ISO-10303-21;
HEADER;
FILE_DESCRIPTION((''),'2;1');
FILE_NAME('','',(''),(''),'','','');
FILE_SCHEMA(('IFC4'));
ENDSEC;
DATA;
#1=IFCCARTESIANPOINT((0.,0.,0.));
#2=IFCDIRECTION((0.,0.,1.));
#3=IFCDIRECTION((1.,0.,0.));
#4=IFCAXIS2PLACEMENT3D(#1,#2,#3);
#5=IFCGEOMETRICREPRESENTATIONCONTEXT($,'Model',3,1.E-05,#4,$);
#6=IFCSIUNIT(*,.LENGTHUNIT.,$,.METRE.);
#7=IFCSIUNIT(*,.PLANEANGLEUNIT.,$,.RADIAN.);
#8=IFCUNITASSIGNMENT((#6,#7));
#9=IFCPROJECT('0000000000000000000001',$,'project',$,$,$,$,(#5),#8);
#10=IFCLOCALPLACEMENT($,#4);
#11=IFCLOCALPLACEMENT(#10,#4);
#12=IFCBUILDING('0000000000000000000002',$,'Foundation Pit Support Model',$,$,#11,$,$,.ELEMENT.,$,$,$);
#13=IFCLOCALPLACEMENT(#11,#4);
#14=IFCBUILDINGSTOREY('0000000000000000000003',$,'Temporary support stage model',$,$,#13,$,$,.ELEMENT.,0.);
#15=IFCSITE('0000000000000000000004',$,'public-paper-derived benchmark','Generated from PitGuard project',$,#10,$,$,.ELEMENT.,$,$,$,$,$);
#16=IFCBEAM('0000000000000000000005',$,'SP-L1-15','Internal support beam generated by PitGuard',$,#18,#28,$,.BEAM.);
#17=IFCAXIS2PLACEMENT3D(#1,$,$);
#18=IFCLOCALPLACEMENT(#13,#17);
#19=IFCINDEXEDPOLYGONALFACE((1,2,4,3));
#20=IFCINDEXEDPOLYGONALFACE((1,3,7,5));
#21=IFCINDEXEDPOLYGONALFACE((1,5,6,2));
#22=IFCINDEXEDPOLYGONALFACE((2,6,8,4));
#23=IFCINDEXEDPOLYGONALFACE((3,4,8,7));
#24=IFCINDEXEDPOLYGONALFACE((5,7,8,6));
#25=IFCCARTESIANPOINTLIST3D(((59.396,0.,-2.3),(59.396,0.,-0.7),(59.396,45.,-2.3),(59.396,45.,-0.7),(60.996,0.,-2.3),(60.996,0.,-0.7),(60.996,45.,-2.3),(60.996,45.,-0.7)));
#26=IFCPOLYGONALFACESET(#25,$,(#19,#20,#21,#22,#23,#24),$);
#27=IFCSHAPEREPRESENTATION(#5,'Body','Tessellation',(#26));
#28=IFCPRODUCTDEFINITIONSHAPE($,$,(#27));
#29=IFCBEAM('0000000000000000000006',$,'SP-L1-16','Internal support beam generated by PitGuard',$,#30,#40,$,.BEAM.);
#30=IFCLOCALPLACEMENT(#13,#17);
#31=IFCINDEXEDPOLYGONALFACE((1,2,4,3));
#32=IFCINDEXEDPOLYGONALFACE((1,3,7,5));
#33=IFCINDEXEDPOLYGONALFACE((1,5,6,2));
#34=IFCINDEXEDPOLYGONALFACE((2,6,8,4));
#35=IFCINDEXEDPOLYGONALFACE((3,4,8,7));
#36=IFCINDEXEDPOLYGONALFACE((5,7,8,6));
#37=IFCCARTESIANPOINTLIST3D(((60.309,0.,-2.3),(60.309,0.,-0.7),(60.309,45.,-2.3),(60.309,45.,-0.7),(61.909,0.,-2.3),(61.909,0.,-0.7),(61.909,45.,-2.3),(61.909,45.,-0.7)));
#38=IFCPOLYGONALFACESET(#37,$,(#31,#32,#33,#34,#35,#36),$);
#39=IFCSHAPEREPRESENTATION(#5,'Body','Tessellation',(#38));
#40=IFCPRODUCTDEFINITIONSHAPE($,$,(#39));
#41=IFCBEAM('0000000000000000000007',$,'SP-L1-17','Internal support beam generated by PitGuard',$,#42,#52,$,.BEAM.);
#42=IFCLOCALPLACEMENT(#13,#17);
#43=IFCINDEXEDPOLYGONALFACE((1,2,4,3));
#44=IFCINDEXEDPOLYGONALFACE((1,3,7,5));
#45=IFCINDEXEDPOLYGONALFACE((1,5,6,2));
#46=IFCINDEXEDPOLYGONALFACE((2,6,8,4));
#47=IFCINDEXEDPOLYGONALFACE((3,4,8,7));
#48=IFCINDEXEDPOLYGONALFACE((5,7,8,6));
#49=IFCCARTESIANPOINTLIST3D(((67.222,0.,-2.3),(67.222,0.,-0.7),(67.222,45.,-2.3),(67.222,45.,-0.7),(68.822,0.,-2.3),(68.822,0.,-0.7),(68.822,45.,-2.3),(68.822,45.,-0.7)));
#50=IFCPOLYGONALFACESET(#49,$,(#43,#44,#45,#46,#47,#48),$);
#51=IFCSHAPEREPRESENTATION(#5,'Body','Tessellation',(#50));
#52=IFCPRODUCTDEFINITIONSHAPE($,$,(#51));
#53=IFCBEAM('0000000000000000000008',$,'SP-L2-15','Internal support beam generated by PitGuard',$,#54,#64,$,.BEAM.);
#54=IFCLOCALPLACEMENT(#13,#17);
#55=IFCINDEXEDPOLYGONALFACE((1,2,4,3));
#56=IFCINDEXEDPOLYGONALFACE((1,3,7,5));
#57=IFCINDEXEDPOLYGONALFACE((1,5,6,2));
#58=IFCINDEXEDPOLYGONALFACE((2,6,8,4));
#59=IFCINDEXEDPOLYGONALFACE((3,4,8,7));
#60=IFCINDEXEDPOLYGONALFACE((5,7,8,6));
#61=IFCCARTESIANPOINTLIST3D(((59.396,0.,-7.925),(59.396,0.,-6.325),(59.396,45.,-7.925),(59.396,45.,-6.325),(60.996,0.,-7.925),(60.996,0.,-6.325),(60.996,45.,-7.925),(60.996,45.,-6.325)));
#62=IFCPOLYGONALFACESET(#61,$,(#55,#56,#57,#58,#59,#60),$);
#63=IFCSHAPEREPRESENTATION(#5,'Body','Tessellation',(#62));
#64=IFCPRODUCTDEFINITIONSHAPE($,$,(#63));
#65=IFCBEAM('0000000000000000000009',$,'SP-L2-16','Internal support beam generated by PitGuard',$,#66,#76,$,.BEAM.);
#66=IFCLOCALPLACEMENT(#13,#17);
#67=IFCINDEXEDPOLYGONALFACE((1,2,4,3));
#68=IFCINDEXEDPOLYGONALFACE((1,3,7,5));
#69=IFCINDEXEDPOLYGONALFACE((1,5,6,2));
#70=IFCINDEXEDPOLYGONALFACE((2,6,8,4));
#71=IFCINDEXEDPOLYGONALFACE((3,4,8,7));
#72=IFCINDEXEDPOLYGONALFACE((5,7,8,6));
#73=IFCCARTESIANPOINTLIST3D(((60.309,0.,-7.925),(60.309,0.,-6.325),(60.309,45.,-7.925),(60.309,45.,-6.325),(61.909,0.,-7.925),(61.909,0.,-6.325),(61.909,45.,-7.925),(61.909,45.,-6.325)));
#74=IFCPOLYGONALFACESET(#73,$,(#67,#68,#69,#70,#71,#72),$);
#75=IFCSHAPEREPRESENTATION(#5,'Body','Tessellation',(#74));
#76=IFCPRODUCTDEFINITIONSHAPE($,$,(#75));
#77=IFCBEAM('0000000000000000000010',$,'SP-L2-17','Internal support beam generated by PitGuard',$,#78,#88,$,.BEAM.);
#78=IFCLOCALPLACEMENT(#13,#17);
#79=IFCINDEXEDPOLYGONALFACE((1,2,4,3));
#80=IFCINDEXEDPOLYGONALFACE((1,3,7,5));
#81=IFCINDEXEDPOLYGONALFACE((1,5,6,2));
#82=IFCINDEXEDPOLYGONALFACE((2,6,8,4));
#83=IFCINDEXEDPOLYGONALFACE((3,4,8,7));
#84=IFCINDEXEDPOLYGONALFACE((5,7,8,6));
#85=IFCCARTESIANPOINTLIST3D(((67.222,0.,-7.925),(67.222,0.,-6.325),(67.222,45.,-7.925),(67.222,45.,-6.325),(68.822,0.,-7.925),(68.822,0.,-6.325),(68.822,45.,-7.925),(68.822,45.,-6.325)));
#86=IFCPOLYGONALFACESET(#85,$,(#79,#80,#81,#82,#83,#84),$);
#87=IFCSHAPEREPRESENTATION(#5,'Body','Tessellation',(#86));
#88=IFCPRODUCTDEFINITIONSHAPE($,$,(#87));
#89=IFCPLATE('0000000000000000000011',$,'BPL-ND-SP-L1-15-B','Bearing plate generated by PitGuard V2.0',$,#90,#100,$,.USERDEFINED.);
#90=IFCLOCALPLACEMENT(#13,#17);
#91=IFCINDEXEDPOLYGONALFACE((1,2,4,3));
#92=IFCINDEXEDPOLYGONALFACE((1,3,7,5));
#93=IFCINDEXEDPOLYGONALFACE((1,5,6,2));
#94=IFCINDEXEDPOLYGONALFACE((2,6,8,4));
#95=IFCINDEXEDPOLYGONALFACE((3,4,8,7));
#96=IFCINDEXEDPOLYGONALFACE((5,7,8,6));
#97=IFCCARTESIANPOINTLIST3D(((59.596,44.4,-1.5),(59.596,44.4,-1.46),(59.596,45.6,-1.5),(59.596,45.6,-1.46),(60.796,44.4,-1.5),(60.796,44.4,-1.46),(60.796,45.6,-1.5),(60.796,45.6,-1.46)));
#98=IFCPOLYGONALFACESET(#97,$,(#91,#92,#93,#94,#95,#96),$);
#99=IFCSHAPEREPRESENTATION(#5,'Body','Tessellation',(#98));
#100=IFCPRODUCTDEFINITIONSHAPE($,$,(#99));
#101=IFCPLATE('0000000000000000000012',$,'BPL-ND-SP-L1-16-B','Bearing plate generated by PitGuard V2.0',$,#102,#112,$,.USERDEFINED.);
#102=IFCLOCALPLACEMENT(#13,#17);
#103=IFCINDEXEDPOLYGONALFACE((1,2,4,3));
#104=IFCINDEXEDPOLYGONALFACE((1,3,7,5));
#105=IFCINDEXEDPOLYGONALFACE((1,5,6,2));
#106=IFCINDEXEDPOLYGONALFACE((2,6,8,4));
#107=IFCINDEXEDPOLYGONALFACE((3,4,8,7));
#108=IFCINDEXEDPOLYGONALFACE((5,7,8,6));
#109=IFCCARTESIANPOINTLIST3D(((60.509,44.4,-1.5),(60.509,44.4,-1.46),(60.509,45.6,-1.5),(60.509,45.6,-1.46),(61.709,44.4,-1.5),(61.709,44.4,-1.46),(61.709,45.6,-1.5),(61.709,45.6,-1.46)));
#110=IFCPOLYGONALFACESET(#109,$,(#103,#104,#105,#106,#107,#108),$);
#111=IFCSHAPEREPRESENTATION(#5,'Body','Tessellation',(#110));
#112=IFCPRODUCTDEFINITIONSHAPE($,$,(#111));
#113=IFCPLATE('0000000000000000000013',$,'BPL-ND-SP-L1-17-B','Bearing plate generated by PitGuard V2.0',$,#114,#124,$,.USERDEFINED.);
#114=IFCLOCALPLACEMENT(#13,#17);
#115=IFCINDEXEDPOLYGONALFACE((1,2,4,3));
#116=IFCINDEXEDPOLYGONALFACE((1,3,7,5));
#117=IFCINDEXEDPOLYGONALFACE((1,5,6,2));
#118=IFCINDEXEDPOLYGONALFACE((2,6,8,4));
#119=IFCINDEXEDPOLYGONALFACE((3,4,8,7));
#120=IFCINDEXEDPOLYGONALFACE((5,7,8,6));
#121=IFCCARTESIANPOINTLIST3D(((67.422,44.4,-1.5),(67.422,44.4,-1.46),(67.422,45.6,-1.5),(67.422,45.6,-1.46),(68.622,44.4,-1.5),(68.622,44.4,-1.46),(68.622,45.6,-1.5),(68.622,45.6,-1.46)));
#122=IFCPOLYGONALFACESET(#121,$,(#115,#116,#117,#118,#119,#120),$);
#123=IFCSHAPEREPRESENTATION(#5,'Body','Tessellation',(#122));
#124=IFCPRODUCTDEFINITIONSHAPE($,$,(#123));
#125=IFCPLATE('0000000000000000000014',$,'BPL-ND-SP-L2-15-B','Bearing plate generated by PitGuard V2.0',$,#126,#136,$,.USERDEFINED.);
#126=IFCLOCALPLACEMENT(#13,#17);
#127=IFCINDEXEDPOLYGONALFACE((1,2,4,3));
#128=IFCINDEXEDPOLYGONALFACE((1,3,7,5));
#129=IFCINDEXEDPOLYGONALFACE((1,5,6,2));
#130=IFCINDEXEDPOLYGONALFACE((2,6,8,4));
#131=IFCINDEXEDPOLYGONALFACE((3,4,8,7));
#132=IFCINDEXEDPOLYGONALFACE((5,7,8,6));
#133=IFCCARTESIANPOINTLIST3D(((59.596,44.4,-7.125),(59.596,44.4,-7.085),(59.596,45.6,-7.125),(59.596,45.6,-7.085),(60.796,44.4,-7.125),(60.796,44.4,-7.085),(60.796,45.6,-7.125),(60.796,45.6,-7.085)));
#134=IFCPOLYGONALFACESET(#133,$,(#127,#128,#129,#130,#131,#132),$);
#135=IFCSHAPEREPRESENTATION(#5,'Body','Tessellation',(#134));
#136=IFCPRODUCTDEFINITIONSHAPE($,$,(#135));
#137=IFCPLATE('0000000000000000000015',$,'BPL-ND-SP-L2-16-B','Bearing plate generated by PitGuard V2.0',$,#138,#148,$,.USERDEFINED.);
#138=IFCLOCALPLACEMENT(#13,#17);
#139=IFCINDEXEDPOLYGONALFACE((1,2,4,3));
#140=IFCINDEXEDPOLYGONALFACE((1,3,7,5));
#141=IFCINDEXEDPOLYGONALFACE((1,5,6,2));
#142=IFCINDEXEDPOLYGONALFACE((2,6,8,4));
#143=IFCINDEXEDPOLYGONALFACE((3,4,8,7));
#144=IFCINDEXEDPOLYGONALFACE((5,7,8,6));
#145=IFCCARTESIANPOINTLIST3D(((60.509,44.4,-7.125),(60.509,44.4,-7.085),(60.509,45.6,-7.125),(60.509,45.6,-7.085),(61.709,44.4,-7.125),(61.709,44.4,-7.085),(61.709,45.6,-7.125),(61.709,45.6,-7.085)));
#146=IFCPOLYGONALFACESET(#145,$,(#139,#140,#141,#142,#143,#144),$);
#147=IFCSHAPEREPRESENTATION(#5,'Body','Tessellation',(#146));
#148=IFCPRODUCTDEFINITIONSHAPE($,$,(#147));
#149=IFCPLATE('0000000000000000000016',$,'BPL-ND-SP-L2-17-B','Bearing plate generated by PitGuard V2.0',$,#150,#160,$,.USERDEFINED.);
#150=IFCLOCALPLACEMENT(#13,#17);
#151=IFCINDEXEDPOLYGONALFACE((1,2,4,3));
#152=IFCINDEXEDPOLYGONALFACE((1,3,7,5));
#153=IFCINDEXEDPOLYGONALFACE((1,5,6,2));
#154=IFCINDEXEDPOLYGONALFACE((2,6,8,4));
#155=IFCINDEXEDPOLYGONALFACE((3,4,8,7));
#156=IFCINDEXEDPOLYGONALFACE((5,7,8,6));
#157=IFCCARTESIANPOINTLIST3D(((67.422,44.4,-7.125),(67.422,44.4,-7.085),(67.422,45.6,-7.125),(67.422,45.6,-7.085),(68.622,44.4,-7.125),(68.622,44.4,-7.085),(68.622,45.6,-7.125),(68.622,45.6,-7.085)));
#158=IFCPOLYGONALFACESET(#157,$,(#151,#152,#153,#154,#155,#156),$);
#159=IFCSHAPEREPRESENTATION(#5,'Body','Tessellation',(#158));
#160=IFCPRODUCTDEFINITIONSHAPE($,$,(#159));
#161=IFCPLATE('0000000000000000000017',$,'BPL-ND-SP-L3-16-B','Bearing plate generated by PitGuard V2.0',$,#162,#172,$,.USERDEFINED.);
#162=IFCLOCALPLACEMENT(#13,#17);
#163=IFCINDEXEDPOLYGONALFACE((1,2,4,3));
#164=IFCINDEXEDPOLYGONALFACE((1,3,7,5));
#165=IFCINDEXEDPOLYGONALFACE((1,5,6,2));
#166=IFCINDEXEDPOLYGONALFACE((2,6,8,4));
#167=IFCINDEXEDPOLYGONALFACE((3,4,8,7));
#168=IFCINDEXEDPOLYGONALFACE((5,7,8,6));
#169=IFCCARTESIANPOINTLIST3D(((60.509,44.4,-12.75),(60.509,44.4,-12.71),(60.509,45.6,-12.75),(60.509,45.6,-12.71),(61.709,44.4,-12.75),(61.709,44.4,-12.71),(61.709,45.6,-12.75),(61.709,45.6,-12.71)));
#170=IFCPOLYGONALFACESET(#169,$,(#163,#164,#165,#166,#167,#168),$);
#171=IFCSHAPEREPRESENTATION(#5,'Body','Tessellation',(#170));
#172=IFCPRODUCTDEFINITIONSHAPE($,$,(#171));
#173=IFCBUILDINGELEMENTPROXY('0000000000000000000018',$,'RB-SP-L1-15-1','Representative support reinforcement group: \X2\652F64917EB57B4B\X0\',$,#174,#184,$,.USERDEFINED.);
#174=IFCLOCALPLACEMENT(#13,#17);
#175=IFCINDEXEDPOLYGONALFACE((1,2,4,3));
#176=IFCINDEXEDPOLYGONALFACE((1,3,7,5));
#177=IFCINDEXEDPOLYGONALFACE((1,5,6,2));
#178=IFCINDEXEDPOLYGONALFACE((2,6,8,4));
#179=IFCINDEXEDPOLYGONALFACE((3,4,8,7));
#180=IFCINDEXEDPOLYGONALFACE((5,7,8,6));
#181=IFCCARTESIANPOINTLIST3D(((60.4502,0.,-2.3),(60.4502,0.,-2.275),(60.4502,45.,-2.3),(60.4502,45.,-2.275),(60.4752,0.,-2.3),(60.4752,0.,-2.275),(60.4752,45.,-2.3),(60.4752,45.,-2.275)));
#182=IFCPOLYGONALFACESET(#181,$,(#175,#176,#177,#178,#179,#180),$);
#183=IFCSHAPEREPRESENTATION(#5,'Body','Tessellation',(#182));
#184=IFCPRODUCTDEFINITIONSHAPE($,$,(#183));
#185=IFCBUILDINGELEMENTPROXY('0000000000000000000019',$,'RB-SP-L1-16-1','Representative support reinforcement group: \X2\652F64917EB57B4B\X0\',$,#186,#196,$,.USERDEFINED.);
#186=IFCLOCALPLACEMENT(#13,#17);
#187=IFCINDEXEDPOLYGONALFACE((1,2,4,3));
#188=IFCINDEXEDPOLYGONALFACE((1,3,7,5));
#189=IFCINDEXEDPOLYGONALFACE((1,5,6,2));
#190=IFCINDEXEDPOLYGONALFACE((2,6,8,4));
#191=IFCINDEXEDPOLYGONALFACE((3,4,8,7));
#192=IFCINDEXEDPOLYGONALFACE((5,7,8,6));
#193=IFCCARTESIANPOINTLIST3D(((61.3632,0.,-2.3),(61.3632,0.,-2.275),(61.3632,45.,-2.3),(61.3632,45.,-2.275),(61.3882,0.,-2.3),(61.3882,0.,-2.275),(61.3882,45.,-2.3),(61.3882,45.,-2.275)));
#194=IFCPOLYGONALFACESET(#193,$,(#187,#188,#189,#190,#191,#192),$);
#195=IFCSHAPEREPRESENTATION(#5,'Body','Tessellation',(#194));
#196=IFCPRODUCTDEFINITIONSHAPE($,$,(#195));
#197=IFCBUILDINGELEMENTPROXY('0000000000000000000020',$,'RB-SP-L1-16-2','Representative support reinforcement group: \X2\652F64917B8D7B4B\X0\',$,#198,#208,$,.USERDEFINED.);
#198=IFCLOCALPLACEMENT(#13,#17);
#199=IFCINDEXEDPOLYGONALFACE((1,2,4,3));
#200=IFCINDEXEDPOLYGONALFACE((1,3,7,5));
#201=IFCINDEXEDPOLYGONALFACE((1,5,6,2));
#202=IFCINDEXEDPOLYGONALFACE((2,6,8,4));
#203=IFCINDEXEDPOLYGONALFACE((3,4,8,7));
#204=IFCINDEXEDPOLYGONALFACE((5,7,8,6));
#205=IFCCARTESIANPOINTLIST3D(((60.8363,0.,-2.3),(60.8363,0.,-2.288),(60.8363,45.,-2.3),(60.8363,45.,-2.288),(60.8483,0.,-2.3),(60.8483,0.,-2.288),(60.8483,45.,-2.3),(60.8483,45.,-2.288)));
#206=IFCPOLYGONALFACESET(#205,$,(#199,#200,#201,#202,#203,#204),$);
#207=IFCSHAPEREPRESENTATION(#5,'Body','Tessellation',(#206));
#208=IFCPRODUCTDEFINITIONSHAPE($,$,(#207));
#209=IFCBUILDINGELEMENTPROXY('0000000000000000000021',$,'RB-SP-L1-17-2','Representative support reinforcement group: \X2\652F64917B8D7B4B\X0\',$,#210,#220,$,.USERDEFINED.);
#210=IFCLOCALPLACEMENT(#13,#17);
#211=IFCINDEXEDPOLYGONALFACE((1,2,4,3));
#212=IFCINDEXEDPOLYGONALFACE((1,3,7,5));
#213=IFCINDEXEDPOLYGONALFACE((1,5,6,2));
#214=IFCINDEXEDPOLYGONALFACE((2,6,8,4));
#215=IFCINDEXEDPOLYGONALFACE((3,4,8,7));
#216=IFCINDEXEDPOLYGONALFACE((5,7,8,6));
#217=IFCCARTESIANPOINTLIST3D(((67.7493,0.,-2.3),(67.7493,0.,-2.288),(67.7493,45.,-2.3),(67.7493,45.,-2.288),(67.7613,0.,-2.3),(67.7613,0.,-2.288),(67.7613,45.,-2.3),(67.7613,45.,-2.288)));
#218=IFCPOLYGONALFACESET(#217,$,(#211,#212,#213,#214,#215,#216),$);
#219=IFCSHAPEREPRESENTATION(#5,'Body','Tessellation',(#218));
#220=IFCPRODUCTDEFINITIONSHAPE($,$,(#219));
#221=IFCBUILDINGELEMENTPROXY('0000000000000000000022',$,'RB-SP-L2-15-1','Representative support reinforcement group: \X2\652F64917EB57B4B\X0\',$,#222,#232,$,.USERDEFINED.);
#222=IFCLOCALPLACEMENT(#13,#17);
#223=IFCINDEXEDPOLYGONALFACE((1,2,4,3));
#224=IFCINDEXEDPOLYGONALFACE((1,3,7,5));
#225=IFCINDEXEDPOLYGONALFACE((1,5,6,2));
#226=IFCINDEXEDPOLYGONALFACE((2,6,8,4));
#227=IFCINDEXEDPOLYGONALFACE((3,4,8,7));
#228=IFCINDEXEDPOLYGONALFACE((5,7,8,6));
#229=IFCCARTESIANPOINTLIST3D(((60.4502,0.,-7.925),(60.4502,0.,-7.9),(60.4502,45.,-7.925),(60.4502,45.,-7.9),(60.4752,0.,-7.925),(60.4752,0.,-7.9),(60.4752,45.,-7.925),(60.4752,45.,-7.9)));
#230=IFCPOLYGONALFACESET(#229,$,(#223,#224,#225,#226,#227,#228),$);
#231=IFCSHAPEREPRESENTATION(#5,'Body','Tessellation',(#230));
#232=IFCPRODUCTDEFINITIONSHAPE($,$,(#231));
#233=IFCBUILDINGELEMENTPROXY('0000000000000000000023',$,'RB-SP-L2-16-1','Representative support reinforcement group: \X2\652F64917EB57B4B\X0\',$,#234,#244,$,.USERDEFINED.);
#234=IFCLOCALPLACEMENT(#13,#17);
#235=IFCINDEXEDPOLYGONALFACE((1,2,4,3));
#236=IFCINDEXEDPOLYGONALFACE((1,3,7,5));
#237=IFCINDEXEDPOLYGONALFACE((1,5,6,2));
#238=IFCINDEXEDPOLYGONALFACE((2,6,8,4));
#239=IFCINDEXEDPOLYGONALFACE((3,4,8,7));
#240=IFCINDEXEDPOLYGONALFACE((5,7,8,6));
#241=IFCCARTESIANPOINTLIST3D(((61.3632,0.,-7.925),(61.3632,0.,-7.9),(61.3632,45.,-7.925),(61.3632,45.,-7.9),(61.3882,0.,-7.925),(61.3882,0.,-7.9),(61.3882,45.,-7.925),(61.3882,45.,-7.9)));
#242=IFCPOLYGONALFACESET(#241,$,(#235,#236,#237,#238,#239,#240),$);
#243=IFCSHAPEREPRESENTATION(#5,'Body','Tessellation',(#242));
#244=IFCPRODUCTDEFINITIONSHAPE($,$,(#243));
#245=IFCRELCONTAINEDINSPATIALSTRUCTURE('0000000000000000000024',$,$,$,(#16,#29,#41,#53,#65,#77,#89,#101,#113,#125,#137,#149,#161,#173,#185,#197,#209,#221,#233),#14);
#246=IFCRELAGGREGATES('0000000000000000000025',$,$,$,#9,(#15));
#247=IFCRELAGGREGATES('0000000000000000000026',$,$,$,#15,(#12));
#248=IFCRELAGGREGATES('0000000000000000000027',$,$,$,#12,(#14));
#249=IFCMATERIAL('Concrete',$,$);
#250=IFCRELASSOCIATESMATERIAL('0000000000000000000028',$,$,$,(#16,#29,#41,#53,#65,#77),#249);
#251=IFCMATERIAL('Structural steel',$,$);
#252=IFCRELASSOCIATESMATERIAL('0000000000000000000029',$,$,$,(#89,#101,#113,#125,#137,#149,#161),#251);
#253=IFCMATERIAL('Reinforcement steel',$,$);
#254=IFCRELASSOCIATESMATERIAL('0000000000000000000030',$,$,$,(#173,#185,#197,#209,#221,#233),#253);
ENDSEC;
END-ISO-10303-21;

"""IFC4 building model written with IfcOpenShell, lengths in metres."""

from ifc_helpers import new_model, si_unit, frame, origin_with_axes, origin_2d, place, context, project, spatial, rectangle, extrude, material, element, save


model = new_model("IFC4")

# Units and contexts
model_context = context("Model", 3, precision=1e-05, world=origin_with_axes())
ifc_project = project(units=[si_unit("LENGTHUNIT", "METRE"), si_unit("PLANEANGLEUNIT", "RADIAN")], contexts=[model_context])

# Site, building, storey
site_placement = place(None, origin_with_axes())
site = spatial("IfcSite", under=ifc_project, at=site_placement, Name="public-paper-derived benchmark", Description="Generated from PitGuard project", CompositionType="ELEMENT")
building_placement = place(site_placement, origin_with_axes())
building = spatial("IfcBuilding", under=site, at=building_placement, Name="Foundation Pit Support Model", CompositionType="ELEMENT")
storey_placement = place(building_placement, origin_with_axes())
storey = spatial("IfcBuildingStorey", under=building, at=storey_placement, Name="Temporary support stage model", CompositionType="ELEMENT", Elevation=0.0)

# Beams
ifc_material_1 = material(Name="Concrete")
for number, where, z_axis, x_axis, name in (
    (1, (60.196, 22.5, -2.3), (0.0, 0.0, 1.0), (0.0, 1.0, 0.0), "SP-L1-15"),
    (2, (61.109, 22.5, -2.3), (0.0, 0.0, 1.0), (0.0, 1.0, 0.0), "SP-L1-16"),
    (3, (68.022, 22.5, -2.3), (0.0, 0.0, 1.0), (0.0, 1.0, 0.0), "SP-L1-17"),
    (4, (60.196, 22.5, -7.925), (0.0, 0.0, 1.0), (0.0, 1.0, 0.0), "SP-L2-15"),
    (5, (61.109, 22.5, -7.925), (0.0, 0.0, 1.0), (0.0, 1.0, 0.0), "SP-L2-16"),
    (6, (68.022, 22.5, -7.925), (0.0, 0.0, 1.0), (0.0, 1.0, 0.0), "SP-L2-17"),
):
    element("IfcBeam", number, at=place(storey_placement, frame(where, z_axis=z_axis, x_axis=x_axis)), inside=storey, material=ifc_material_1, Name=name, Description="Internal support beam generated by PitGuard", PredefinedType="BEAM", context=model_context, shape_type="SweptSolid", body=[
        extrude(rectangle(XDim=45.0, YDim=1.6, at=origin_2d()), origin_with_axes(), (0.0, 0.0, 1.0), 1.6),
    ])

# Plates
ifc_material_2 = material(Name="Structural steel")
for number, where, z_axis, x_axis, name in (
    (7, (60.196, 45.0, -1.5), (0.0, 0.0, 1.0), (1.0, 0.0, 0.0), "BPL-ND-SP-L1-15-B"),
    (8, (61.109, 45.0, -1.5), (0.0, 0.0, 1.0), (1.0, 0.0, 0.0), "BPL-ND-SP-L1-16-B"),
    (9, (68.022, 45.0, -1.5), (0.0, 0.0, 1.0), (1.0, 0.0, 0.0), "BPL-ND-SP-L1-17-B"),
    (10, (60.196, 45.0, -7.125), (0.0, 0.0, 1.0), (1.0, 0.0, 0.0), "BPL-ND-SP-L2-15-B"),
    (11, (61.109, 45.0, -7.125), (0.0, 0.0, 1.0), (1.0, 0.0, 0.0), "BPL-ND-SP-L2-16-B"),
    (12, (68.022, 45.0, -7.125), (0.0, 0.0, 1.0), (1.0, 0.0, 0.0), "BPL-ND-SP-L2-17-B"),
    (13, (61.109, 45.0, -12.75), (0.0, 0.0, 1.0), (1.0, 0.0, 0.0), "BPL-ND-SP-L3-16-B"),
):
    element("IfcPlate", number, at=place(storey_placement, frame(where, z_axis=z_axis, x_axis=x_axis)), inside=storey, material=ifc_material_2, Name=name, Description="Bearing plate generated by PitGuard V2.0", PredefinedType="USERDEFINED", context=model_context, shape_type="SweptSolid", body=[
        extrude(rectangle(XDim=1.2, YDim=1.2, at=origin_2d()), origin_with_axes(), (0.0, 0.0, 1.0), 0.04),
    ])

# Building element proxies
ifc_material_3 = material(Name="Reinforcement steel")
for number, where, z_axis, x_axis, name in (
    (14, (60.4627, 22.5, -2.3), (0.0, 0.0, 1.0), (0.0, 1.0, 0.0), "RB-SP-L1-15-1"),
    (15, (61.3757, 22.5, -2.3), (0.0, 0.0, 1.0), (0.0, 1.0, 0.0), "RB-SP-L1-16-1"),
):
    element("IfcBuildingElementProxy", number, at=place(storey_placement, frame(where, z_axis=z_axis, x_axis=x_axis)), inside=storey, material=ifc_material_3, Name=name, Description="Representative support reinforcement group: 支撑纵筋", PredefinedType="USERDEFINED", context=model_context, shape_type="SweptSolid", body=[
        extrude(rectangle(XDim=45.0, YDim=0.025, at=origin_2d()), origin_with_axes(), (0.0, 0.0, 1.0), 0.025),
    ])
for number, where, z_axis, x_axis, name in (
    (16, (60.8423, 22.5, -2.3), (0.0, 0.0, 1.0), (0.0, 1.0, 0.0), "RB-SP-L1-16-2"),
    (17, (67.7553, 22.5, -2.3), (0.0, 0.0, 1.0), (0.0, 1.0, 0.0), "RB-SP-L1-17-2"),
):
    element("IfcBuildingElementProxy", number, at=place(storey_placement, frame(where, z_axis=z_axis, x_axis=x_axis)), inside=storey, material=ifc_material_3, Name=name, Description="Representative support reinforcement group: 支撑箍筋", PredefinedType="USERDEFINED", context=model_context, shape_type="SweptSolid", body=[
        extrude(rectangle(XDim=45.0, YDim=0.012, at=origin_2d()), origin_with_axes(), (0.0, 0.0, 1.0), 0.012),
    ])
for number, where, z_axis, x_axis, name in (
    (18, (60.4627, 22.5, -7.925), (0.0, 0.0, 1.0), (0.0, 1.0, 0.0), "RB-SP-L2-15-1"),
    (19, (61.3757, 22.5, -7.925), (0.0, 0.0, 1.0), (0.0, 1.0, 0.0), "RB-SP-L2-16-1"),
):
    element("IfcBuildingElementProxy", number, at=place(storey_placement, frame(where, z_axis=z_axis, x_axis=x_axis)), inside=storey, material=ifc_material_3, Name=name, Description="Representative support reinforcement group: 支撑纵筋", PredefinedType="USERDEFINED", context=model_context, shape_type="SweptSolid", body=[
        extrude(rectangle(XDim=45.0, YDim=0.025, at=origin_2d()), origin_with_axes(), (0.0, 0.0, 1.0), 0.025),
    ])

save(model, "model.ifc")
